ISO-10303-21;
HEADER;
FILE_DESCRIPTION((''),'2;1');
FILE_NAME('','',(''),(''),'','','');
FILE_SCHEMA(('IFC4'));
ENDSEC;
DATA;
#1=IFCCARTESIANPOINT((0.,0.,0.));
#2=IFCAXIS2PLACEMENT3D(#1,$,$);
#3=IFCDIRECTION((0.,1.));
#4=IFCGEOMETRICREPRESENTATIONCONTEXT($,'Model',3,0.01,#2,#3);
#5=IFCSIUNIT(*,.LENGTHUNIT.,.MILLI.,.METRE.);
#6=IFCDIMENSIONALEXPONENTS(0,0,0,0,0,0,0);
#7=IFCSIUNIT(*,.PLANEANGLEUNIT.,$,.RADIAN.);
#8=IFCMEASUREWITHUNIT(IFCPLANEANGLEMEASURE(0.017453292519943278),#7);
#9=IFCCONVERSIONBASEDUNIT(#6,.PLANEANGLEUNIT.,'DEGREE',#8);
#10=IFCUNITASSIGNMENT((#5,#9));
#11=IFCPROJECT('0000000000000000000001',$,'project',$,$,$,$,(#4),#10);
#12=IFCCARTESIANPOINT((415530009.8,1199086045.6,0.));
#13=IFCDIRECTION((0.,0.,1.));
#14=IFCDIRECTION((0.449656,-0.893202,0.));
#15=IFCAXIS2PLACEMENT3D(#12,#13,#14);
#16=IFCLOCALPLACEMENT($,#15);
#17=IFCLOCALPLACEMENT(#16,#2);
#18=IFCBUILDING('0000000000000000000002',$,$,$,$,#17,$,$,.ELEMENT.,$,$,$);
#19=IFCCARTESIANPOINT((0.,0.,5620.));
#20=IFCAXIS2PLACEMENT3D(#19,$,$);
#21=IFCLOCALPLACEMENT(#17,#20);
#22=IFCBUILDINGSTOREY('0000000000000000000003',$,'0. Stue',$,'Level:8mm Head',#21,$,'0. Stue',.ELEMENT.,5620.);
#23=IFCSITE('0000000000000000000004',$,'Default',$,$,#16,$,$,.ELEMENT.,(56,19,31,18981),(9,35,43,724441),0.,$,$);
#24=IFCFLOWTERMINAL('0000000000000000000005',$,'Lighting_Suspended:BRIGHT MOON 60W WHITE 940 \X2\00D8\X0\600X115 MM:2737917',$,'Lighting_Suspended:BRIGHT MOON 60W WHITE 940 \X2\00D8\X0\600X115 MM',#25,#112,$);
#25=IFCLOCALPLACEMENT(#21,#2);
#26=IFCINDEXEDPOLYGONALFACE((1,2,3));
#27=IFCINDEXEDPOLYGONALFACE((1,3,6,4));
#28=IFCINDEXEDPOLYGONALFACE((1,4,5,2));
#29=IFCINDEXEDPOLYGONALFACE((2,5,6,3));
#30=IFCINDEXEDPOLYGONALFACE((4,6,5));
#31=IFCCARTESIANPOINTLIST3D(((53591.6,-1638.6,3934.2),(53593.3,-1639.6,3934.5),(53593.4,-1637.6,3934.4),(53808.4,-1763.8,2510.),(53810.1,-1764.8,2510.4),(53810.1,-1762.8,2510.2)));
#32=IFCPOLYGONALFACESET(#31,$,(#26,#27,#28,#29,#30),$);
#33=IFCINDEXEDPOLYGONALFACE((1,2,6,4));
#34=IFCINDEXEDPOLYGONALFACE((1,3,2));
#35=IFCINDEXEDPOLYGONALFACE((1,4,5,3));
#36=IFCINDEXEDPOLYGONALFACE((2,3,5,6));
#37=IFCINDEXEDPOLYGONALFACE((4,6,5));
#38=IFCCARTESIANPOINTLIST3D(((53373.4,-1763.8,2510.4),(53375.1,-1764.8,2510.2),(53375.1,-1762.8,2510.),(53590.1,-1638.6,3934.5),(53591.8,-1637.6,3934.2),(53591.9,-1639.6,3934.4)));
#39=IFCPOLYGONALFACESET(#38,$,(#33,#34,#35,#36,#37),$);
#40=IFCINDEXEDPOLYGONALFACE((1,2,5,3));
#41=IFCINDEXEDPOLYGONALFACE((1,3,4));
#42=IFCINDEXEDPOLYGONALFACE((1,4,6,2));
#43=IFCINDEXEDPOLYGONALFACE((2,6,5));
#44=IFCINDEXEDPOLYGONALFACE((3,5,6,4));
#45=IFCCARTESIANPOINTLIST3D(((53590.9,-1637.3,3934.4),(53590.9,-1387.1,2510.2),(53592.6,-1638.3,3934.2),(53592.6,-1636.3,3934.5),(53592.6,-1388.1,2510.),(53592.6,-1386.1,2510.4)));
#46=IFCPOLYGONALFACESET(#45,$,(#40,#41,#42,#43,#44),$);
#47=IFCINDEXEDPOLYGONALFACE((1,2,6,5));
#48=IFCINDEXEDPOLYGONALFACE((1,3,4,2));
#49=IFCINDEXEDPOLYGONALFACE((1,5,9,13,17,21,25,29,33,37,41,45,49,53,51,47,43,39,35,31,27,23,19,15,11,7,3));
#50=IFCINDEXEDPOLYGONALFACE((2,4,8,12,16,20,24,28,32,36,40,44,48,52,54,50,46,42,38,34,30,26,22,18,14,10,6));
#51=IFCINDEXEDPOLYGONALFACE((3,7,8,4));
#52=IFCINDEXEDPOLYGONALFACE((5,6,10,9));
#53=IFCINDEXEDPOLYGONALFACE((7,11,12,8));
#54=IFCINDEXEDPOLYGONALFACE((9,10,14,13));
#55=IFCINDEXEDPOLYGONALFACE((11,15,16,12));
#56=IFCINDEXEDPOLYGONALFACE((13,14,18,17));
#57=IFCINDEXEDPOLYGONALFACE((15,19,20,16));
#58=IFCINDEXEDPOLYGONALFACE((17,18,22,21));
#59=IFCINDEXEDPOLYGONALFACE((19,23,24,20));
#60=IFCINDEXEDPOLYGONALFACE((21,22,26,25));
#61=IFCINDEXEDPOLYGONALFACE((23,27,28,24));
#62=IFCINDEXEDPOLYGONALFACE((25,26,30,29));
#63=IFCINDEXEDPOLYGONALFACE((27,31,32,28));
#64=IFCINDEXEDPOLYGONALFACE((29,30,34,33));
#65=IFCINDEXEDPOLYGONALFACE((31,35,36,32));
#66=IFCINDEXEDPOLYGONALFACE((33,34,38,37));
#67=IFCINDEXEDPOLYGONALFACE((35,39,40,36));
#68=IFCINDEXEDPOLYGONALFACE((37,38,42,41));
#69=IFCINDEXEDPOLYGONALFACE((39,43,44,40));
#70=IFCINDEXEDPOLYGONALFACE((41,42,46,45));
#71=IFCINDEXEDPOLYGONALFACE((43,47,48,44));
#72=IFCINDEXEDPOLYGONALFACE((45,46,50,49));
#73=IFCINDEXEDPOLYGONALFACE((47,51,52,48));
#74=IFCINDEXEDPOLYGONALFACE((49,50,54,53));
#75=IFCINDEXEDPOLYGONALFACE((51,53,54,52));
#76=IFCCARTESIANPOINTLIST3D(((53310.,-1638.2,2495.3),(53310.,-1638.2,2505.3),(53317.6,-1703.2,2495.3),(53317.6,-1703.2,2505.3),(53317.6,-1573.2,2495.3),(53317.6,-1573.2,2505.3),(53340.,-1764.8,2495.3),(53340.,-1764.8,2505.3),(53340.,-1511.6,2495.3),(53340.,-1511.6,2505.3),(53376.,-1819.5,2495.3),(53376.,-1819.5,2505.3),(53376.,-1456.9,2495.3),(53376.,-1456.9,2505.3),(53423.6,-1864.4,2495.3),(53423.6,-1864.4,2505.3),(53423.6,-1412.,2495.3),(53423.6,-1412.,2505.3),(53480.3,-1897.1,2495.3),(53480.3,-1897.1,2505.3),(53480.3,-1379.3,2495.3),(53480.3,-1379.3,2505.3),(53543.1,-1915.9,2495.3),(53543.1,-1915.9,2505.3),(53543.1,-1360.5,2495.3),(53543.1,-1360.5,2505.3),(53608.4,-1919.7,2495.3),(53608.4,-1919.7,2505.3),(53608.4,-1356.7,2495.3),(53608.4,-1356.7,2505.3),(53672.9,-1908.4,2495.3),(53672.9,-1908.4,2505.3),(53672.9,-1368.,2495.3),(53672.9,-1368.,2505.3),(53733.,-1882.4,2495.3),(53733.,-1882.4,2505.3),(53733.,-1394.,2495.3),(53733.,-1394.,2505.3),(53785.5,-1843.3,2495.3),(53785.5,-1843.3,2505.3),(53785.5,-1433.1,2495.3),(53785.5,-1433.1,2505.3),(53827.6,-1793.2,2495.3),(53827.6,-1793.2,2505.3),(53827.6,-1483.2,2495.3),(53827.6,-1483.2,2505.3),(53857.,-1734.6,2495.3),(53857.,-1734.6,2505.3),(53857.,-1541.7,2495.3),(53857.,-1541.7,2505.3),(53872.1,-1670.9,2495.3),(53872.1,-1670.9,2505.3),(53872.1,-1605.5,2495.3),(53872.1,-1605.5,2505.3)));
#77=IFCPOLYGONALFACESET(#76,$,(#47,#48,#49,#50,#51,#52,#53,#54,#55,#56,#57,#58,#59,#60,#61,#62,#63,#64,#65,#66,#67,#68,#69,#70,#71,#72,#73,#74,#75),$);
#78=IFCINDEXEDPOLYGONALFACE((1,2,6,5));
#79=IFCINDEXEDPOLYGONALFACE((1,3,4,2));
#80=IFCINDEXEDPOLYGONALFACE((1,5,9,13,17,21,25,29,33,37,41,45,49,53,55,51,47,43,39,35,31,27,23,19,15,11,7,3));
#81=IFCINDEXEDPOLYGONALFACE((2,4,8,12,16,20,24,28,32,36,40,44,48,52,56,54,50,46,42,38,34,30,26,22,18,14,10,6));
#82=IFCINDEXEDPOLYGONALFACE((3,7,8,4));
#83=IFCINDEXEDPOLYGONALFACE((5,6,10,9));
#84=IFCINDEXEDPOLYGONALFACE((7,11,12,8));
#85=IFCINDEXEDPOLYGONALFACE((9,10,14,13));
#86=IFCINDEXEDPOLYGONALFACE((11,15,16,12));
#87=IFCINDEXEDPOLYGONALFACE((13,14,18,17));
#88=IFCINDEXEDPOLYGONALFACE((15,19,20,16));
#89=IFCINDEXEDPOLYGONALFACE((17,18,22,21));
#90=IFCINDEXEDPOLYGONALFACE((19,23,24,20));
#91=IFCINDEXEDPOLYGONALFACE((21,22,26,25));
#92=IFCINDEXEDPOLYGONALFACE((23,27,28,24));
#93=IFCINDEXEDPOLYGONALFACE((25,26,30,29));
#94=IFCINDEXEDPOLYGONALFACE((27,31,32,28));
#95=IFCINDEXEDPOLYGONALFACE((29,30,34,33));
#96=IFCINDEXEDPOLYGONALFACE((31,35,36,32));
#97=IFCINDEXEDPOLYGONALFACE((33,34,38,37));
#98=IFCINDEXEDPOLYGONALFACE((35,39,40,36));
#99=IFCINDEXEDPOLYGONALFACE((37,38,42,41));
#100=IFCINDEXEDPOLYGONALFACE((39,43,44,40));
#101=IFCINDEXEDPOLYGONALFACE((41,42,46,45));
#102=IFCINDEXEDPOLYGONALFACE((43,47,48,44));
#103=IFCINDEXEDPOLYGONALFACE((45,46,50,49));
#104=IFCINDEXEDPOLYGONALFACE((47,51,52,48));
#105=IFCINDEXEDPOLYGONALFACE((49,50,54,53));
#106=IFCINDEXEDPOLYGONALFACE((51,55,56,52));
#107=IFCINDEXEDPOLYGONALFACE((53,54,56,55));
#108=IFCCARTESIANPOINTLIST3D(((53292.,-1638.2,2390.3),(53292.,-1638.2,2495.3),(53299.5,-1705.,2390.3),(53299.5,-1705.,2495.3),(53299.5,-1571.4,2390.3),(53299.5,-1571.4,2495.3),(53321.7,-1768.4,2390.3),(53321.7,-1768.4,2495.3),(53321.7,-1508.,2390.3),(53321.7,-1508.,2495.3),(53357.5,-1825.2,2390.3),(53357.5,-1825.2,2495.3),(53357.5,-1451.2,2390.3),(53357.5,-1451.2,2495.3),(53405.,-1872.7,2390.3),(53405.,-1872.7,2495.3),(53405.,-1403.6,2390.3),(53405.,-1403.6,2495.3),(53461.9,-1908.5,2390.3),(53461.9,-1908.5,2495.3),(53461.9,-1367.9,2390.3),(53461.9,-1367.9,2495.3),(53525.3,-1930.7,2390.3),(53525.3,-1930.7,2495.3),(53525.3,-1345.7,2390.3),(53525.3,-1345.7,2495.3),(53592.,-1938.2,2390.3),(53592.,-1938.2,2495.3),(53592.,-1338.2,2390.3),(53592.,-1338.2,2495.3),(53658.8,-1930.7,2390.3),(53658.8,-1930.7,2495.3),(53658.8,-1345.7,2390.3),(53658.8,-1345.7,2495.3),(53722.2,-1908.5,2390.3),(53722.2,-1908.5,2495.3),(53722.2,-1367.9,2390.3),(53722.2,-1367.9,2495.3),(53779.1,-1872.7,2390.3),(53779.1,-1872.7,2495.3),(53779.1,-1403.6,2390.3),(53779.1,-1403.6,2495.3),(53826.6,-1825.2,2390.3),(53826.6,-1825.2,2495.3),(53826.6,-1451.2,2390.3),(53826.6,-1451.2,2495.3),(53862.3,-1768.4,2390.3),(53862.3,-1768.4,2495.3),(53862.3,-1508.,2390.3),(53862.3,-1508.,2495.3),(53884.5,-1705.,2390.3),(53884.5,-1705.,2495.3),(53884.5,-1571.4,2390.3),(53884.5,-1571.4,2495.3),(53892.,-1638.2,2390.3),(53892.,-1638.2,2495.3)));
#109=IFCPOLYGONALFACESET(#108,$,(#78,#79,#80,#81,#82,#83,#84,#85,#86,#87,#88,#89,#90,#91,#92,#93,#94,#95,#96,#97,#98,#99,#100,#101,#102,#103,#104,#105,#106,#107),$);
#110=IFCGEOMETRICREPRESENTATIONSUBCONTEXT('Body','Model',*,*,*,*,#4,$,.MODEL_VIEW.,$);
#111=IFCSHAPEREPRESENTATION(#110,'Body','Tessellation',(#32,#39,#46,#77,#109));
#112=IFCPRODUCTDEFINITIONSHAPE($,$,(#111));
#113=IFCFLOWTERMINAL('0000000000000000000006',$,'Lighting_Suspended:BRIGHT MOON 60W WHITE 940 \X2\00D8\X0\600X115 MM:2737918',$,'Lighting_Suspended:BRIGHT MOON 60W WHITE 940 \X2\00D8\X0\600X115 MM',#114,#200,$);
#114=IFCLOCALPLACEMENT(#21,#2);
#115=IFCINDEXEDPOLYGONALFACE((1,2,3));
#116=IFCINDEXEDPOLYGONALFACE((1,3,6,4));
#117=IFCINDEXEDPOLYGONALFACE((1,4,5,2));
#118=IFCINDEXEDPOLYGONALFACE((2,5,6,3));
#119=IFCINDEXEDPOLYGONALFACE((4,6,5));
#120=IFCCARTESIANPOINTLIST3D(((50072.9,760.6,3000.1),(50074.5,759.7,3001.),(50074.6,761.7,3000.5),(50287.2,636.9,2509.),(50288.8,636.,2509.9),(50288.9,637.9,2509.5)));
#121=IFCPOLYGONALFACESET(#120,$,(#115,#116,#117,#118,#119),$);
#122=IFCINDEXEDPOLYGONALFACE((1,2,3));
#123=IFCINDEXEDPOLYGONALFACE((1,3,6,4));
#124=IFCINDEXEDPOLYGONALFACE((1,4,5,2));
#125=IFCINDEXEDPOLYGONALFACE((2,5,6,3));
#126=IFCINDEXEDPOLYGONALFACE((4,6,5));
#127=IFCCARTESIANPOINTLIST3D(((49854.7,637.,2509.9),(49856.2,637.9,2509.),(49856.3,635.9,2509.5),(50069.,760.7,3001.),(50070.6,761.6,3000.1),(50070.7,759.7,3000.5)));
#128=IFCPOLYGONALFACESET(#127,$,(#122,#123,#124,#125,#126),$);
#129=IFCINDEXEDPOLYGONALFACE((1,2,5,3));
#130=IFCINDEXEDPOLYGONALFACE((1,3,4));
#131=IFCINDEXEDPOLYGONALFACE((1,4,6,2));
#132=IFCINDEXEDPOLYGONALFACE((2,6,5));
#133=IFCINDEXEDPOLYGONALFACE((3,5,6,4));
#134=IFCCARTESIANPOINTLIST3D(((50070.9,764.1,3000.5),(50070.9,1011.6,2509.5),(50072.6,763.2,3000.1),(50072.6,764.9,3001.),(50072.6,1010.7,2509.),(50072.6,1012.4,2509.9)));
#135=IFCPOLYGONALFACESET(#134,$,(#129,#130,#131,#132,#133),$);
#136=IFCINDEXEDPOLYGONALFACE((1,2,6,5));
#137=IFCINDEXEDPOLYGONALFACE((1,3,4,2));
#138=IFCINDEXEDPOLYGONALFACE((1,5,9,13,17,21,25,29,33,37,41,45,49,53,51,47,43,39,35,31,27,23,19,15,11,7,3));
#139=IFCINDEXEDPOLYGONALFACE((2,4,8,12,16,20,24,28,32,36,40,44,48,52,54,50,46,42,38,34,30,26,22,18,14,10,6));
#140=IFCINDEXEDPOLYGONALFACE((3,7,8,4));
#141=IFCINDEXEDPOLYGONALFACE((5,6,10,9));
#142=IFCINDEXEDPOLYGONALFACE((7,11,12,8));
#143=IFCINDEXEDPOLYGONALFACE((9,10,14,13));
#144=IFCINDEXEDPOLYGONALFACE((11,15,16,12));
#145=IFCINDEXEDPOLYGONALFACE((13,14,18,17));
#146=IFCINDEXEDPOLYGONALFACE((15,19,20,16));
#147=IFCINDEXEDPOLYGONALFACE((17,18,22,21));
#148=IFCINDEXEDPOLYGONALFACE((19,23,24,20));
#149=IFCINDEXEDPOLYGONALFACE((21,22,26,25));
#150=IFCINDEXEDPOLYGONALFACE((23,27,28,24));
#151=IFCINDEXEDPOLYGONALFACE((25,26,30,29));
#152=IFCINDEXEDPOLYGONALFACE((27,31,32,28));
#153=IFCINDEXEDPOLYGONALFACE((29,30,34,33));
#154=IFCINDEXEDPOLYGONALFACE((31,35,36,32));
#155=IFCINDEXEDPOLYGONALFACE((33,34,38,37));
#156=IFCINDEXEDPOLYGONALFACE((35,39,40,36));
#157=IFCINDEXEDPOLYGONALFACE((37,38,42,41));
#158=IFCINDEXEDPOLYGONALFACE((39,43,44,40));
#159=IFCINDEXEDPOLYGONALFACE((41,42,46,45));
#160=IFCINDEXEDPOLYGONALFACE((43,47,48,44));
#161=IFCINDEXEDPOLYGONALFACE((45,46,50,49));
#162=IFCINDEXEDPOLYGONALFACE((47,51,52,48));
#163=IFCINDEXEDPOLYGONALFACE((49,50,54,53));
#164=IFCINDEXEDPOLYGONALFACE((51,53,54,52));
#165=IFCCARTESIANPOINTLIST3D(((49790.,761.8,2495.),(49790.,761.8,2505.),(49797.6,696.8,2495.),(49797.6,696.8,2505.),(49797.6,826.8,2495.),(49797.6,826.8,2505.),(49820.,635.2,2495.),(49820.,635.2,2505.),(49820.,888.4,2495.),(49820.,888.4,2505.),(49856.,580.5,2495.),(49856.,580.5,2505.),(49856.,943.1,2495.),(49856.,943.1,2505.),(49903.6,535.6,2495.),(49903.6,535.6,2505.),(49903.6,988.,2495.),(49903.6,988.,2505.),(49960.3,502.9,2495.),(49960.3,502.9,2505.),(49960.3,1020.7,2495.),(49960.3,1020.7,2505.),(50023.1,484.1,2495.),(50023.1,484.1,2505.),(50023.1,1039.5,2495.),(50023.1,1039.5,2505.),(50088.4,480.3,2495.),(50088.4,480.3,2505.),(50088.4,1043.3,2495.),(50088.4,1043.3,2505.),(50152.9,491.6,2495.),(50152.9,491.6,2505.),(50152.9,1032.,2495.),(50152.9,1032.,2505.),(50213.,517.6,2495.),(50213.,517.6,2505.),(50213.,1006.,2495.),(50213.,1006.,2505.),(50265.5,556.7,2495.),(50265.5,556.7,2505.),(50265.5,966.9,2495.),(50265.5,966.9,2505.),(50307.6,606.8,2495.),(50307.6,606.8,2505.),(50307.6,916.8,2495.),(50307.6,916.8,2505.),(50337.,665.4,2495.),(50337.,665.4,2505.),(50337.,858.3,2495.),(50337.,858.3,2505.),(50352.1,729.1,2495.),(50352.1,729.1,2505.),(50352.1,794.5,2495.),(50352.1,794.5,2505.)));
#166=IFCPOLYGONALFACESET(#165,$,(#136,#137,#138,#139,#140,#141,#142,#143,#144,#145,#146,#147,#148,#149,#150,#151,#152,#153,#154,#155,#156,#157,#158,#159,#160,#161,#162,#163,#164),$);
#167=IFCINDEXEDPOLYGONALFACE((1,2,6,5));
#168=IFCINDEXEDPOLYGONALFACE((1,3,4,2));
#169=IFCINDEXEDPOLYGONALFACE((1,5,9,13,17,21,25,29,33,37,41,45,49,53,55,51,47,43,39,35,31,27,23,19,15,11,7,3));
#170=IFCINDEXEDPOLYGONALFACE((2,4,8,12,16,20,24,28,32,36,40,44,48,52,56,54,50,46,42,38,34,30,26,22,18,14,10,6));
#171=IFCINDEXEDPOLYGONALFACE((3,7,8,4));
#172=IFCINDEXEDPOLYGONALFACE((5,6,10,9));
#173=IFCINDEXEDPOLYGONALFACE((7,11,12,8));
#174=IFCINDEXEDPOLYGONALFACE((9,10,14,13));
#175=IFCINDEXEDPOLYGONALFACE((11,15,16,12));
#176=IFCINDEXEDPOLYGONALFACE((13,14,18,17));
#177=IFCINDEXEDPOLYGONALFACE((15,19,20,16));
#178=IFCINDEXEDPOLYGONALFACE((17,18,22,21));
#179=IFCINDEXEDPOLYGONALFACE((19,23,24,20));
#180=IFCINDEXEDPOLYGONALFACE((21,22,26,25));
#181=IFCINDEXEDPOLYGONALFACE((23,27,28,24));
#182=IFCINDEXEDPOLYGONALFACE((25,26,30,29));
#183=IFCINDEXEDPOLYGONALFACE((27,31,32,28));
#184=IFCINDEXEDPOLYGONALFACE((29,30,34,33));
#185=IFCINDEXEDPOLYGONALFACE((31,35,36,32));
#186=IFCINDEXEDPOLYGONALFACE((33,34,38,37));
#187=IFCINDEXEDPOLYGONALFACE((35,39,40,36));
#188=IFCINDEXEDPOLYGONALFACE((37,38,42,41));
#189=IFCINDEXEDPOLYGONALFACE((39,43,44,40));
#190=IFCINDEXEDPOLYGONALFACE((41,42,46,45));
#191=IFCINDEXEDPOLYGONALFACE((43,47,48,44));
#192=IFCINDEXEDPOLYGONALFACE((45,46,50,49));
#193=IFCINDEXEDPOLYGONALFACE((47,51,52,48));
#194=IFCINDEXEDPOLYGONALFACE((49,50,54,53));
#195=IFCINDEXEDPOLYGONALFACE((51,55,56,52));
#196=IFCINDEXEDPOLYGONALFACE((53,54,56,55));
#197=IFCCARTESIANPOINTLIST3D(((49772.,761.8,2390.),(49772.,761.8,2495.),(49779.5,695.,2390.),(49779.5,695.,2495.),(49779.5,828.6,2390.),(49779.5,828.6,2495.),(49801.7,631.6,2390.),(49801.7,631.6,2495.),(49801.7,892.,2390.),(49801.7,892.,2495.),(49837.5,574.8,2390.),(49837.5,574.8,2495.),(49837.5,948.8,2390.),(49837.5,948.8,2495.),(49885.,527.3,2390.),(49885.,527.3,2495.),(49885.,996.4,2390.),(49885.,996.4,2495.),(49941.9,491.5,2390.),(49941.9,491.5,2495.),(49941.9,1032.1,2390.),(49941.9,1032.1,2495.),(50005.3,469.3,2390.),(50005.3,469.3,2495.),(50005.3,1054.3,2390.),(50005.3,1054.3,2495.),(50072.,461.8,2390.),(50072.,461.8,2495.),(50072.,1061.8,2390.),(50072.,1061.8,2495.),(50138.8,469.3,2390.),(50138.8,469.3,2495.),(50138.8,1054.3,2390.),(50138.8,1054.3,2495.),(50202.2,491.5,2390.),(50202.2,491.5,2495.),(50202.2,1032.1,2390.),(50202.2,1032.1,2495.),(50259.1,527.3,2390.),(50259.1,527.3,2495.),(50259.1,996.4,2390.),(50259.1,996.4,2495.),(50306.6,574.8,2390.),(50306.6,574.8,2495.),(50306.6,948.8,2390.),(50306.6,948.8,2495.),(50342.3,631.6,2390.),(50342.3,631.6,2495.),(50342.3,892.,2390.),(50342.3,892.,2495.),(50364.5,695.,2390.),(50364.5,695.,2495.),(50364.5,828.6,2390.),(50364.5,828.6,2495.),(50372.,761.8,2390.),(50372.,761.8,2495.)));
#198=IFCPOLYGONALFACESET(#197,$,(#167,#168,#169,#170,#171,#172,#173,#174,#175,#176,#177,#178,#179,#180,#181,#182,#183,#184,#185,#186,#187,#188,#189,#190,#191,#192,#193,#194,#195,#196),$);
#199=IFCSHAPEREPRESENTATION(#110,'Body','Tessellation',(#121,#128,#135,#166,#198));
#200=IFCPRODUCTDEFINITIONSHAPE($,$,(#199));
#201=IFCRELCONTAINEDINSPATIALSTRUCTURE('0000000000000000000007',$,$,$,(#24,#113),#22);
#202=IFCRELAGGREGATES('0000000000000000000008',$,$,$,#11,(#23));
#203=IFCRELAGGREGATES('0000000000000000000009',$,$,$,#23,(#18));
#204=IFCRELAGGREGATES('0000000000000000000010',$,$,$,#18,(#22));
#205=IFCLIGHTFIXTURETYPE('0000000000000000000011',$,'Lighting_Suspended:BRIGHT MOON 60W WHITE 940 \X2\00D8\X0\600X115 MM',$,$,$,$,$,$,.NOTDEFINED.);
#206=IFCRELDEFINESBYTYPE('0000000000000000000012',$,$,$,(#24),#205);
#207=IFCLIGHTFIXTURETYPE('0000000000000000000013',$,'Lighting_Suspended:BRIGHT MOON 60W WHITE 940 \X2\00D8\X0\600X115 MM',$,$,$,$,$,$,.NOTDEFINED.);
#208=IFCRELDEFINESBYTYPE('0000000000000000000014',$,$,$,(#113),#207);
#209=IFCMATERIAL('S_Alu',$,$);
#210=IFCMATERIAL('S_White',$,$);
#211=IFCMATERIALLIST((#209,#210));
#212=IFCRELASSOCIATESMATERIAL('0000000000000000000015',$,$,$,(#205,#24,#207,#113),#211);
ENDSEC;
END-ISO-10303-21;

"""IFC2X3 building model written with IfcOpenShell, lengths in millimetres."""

from ifc_helpers import new_model, entity, si_unit, converted_unit, direction, frame, frame_2d, origin, place, context, subcontext, project, spatial, polyline, circle, outline, extrude, source, transform, mapped, material, material_list, type_object, type_shapes, element, save


model = new_model("IFC2X3")

# Units and contexts
model_context = context("Model", 3, precision=0.01, world=origin(), true_north=direction((0.0, 1.0)))
body_context = subcontext(model_context, "Body", "Model", "MODEL_VIEW")
ifc_project = project(units=[si_unit("LENGTHUNIT", "METRE", prefix="MILLI"), converted_unit("PLANEANGLEUNIT", "DEGREE", entity("IfcPlaneAngleMeasure", 0.017453292519943278), si_unit("PLANEANGLEUNIT", "RADIAN"), dimensions=[0, 0, 0, 0, 0, 0, 0])], contexts=[model_context])

# Site, building, storey
site_placement = place(None, frame((415530009.8, 1199086045.6, 0.0), z_axis=(0.0, 0.0, 1.0), x_axis=(0.449656, -0.893202, 0.0)))
site = spatial("IfcSite", under=ifc_project, at=site_placement, Name="Default", CompositionType="ELEMENT", RefLatitude=(56, 19, 31, 18981), RefLongitude=(9, 35, 43, 724441), RefElevation=0.0)
building_placement = place(site_placement, origin())
building = spatial("IfcBuilding", under=site, at=building_placement, CompositionType="ELEMENT")
storey_placement = place(building_placement, frame((0.0, 0.0, 5620.0)))
storey = spatial("IfcBuildingStorey", under=building, at=storey_placement, Name="0. Stue", ObjectType="Level:8mm Head", LongName="0. Stue", CompositionType="ELEMENT", Elevation=5620.0)

# Flow terminals
ifc_material_1 = material(Name="S_White")
ifc_material_2 = material(Name="S_Alu")
ifc_material_list = material_list([ifc_material_2, ifc_material_1])
light_fixture_type_1 = type_object("IfcLightFixtureType", Name="Lighting_Suspended:BRIGHT MOON 60W WHITE 940 Ø600X115 MM", PredefinedType="NOTDEFINED", material=ifc_material_list)
shared_shape_1 = source(origin(), body_context, "Body", "SweptSolid", [
    extrude(outline(polyline([(-1.0, -0.6), (1.0, -0.6), (0.0, 1.2), (-1.0, -0.6)])), frame((-217.5, 125.6, -1429.1), z_axis=(0.149892, -0.08654, 0.984908), x_axis=(-0.852955, 0.492454, 0.17308)), (0.0, 0.0, 1.0), 1446.0),
    extrude(outline(polyline([(-1.0, -0.6), (1.0, -0.6), (0.0, 1.2), (-1.0, -0.6)])), frame((217.5, 125.6, -1429.1), z_axis=(-0.149892, -0.08654, 0.984908), x_axis=(0.852955, 0.492454, 0.17308)), (0.0, 0.0, 1.0), 1446.0),
    extrude(outline(polyline([(-1.0, -0.6), (1.0, -0.6), (0.0, 1.2), (-1.0, -0.6)])), frame((0.0, -251.1, -1429.1), z_axis=(0.0, 0.17308, 0.984908), x_axis=(0.0, -0.984908, 0.17308)), (0.0, 0.0, 1.0), 1446.0),
    extrude(circle(Radius=282.0, at=frame_2d((0.0, 0.0), x_axis=(1.0, 0.0))), frame((0.0, 0.0, -1444.0)), (0.0, 0.0, 1.0), 10.0),
    extrude(circle(Radius=300.0, at=frame_2d((0.0, 0.0), x_axis=(1.0, 0.0))), frame((0.0, 0.0, -1549.0)), (0.0, 0.0, 1.0), 105.0),
])
type_shapes(light_fixture_type_1, [shared_shape_1])
for number, where, z_axis, x_axis, name in (
    (1, (53592.0, -1638.2, 3939.3), (0.0, 0.0, 1.0), (-1.0, 0.0, 0.0), "Lighting_Suspended:BRIGHT MOON 60W WHITE 940 Ø600X115 MM:2737917"),
):
    element("IfcFlowTerminal", number, at=place(storey_placement, frame(where, z_axis=z_axis, x_axis=x_axis)), inside=storey, type_object=light_fixture_type_1, material=ifc_material_list, Name=name, ObjectType="Lighting_Suspended:BRIGHT MOON 60W WHITE 940 Ø600X115 MM", context=body_context, shape_type="MappedRepresentation", body=[
        mapped(shared_shape_1, transform((0.0, 0.0, 0.0), scale=1.0)),
    ])
light_fixture_type_2 = type_object("IfcLightFixtureType", Name="Lighting_Suspended:BRIGHT MOON 60W WHITE 940 Ø600X115 MM", PredefinedType="NOTDEFINED", material=ifc_material_list)
shared_shape_2 = source(origin(), body_context, "Body", "SweptSolid", [
    extrude(outline(polyline([(-1.0, -0.6), (1.0, -0.6), (0.0, 1.2), (-1.0, -0.6)])), frame((-216.3, 124.9, -495.5), z_axis=(0.389771, -0.225034, 0.892994), x_axis=(-0.773355, 0.446497, 0.450069)), (0.0, 0.0, 1.0), 549.9),
    extrude(outline(polyline([(-1.0, -0.6), (1.0, -0.6), (0.0, 1.2), (-1.0, -0.6)])), frame((216.3, 124.9, -495.5), z_axis=(-0.389771, -0.225034, 0.892994), x_axis=(0.773355, 0.446497, 0.450069)), (0.0, 0.0, 1.0), 549.9),
    extrude(outline(polyline([(-1.0, -0.6), (1.0, -0.6), (0.0, 1.2), (-1.0, -0.6)])), frame((0.0, -249.7, -495.5), z_axis=(0.0, 0.450069, 0.892994), x_axis=(0.0, -0.892994, 0.450069)), (0.0, 0.0, 1.0), 549.9),
    extrude(circle(Radius=282.0, at=frame_2d((0.0, 0.0), x_axis=(1.0, 0.0))), frame((0.0, 0.0, -510.0)), (0.0, 0.0, 1.0), 10.0),
    extrude(circle(Radius=300.0, at=frame_2d((0.0, 0.0), x_axis=(1.0, 0.0))), frame((0.0, 0.0, -615.0)), (0.0, 0.0, 1.0), 105.0),
])
type_shapes(light_fixture_type_2, [shared_shape_2])
for number, where, z_axis, x_axis, name in (
    (2, (50072.0, 761.8, 3005.0), (0.0, 0.0, 1.0), (-1.0, 0.0, 0.0), "Lighting_Suspended:BRIGHT MOON 60W WHITE 940 Ø600X115 MM:2737918"),
):
    element("IfcFlowTerminal", number, at=place(storey_placement, frame(where, z_axis=z_axis, x_axis=x_axis)), inside=storey, type_object=light_fixture_type_2, material=ifc_material_list, Name=name, ObjectType="Lighting_Suspended:BRIGHT MOON 60W WHITE 940 Ø600X115 MM", context=body_context, shape_type="MappedRepresentation", body=[
        mapped(shared_shape_2, transform((0.0, 0.0, 0.0), scale=1.0)),
    ])

save(model, "model.ifc")
